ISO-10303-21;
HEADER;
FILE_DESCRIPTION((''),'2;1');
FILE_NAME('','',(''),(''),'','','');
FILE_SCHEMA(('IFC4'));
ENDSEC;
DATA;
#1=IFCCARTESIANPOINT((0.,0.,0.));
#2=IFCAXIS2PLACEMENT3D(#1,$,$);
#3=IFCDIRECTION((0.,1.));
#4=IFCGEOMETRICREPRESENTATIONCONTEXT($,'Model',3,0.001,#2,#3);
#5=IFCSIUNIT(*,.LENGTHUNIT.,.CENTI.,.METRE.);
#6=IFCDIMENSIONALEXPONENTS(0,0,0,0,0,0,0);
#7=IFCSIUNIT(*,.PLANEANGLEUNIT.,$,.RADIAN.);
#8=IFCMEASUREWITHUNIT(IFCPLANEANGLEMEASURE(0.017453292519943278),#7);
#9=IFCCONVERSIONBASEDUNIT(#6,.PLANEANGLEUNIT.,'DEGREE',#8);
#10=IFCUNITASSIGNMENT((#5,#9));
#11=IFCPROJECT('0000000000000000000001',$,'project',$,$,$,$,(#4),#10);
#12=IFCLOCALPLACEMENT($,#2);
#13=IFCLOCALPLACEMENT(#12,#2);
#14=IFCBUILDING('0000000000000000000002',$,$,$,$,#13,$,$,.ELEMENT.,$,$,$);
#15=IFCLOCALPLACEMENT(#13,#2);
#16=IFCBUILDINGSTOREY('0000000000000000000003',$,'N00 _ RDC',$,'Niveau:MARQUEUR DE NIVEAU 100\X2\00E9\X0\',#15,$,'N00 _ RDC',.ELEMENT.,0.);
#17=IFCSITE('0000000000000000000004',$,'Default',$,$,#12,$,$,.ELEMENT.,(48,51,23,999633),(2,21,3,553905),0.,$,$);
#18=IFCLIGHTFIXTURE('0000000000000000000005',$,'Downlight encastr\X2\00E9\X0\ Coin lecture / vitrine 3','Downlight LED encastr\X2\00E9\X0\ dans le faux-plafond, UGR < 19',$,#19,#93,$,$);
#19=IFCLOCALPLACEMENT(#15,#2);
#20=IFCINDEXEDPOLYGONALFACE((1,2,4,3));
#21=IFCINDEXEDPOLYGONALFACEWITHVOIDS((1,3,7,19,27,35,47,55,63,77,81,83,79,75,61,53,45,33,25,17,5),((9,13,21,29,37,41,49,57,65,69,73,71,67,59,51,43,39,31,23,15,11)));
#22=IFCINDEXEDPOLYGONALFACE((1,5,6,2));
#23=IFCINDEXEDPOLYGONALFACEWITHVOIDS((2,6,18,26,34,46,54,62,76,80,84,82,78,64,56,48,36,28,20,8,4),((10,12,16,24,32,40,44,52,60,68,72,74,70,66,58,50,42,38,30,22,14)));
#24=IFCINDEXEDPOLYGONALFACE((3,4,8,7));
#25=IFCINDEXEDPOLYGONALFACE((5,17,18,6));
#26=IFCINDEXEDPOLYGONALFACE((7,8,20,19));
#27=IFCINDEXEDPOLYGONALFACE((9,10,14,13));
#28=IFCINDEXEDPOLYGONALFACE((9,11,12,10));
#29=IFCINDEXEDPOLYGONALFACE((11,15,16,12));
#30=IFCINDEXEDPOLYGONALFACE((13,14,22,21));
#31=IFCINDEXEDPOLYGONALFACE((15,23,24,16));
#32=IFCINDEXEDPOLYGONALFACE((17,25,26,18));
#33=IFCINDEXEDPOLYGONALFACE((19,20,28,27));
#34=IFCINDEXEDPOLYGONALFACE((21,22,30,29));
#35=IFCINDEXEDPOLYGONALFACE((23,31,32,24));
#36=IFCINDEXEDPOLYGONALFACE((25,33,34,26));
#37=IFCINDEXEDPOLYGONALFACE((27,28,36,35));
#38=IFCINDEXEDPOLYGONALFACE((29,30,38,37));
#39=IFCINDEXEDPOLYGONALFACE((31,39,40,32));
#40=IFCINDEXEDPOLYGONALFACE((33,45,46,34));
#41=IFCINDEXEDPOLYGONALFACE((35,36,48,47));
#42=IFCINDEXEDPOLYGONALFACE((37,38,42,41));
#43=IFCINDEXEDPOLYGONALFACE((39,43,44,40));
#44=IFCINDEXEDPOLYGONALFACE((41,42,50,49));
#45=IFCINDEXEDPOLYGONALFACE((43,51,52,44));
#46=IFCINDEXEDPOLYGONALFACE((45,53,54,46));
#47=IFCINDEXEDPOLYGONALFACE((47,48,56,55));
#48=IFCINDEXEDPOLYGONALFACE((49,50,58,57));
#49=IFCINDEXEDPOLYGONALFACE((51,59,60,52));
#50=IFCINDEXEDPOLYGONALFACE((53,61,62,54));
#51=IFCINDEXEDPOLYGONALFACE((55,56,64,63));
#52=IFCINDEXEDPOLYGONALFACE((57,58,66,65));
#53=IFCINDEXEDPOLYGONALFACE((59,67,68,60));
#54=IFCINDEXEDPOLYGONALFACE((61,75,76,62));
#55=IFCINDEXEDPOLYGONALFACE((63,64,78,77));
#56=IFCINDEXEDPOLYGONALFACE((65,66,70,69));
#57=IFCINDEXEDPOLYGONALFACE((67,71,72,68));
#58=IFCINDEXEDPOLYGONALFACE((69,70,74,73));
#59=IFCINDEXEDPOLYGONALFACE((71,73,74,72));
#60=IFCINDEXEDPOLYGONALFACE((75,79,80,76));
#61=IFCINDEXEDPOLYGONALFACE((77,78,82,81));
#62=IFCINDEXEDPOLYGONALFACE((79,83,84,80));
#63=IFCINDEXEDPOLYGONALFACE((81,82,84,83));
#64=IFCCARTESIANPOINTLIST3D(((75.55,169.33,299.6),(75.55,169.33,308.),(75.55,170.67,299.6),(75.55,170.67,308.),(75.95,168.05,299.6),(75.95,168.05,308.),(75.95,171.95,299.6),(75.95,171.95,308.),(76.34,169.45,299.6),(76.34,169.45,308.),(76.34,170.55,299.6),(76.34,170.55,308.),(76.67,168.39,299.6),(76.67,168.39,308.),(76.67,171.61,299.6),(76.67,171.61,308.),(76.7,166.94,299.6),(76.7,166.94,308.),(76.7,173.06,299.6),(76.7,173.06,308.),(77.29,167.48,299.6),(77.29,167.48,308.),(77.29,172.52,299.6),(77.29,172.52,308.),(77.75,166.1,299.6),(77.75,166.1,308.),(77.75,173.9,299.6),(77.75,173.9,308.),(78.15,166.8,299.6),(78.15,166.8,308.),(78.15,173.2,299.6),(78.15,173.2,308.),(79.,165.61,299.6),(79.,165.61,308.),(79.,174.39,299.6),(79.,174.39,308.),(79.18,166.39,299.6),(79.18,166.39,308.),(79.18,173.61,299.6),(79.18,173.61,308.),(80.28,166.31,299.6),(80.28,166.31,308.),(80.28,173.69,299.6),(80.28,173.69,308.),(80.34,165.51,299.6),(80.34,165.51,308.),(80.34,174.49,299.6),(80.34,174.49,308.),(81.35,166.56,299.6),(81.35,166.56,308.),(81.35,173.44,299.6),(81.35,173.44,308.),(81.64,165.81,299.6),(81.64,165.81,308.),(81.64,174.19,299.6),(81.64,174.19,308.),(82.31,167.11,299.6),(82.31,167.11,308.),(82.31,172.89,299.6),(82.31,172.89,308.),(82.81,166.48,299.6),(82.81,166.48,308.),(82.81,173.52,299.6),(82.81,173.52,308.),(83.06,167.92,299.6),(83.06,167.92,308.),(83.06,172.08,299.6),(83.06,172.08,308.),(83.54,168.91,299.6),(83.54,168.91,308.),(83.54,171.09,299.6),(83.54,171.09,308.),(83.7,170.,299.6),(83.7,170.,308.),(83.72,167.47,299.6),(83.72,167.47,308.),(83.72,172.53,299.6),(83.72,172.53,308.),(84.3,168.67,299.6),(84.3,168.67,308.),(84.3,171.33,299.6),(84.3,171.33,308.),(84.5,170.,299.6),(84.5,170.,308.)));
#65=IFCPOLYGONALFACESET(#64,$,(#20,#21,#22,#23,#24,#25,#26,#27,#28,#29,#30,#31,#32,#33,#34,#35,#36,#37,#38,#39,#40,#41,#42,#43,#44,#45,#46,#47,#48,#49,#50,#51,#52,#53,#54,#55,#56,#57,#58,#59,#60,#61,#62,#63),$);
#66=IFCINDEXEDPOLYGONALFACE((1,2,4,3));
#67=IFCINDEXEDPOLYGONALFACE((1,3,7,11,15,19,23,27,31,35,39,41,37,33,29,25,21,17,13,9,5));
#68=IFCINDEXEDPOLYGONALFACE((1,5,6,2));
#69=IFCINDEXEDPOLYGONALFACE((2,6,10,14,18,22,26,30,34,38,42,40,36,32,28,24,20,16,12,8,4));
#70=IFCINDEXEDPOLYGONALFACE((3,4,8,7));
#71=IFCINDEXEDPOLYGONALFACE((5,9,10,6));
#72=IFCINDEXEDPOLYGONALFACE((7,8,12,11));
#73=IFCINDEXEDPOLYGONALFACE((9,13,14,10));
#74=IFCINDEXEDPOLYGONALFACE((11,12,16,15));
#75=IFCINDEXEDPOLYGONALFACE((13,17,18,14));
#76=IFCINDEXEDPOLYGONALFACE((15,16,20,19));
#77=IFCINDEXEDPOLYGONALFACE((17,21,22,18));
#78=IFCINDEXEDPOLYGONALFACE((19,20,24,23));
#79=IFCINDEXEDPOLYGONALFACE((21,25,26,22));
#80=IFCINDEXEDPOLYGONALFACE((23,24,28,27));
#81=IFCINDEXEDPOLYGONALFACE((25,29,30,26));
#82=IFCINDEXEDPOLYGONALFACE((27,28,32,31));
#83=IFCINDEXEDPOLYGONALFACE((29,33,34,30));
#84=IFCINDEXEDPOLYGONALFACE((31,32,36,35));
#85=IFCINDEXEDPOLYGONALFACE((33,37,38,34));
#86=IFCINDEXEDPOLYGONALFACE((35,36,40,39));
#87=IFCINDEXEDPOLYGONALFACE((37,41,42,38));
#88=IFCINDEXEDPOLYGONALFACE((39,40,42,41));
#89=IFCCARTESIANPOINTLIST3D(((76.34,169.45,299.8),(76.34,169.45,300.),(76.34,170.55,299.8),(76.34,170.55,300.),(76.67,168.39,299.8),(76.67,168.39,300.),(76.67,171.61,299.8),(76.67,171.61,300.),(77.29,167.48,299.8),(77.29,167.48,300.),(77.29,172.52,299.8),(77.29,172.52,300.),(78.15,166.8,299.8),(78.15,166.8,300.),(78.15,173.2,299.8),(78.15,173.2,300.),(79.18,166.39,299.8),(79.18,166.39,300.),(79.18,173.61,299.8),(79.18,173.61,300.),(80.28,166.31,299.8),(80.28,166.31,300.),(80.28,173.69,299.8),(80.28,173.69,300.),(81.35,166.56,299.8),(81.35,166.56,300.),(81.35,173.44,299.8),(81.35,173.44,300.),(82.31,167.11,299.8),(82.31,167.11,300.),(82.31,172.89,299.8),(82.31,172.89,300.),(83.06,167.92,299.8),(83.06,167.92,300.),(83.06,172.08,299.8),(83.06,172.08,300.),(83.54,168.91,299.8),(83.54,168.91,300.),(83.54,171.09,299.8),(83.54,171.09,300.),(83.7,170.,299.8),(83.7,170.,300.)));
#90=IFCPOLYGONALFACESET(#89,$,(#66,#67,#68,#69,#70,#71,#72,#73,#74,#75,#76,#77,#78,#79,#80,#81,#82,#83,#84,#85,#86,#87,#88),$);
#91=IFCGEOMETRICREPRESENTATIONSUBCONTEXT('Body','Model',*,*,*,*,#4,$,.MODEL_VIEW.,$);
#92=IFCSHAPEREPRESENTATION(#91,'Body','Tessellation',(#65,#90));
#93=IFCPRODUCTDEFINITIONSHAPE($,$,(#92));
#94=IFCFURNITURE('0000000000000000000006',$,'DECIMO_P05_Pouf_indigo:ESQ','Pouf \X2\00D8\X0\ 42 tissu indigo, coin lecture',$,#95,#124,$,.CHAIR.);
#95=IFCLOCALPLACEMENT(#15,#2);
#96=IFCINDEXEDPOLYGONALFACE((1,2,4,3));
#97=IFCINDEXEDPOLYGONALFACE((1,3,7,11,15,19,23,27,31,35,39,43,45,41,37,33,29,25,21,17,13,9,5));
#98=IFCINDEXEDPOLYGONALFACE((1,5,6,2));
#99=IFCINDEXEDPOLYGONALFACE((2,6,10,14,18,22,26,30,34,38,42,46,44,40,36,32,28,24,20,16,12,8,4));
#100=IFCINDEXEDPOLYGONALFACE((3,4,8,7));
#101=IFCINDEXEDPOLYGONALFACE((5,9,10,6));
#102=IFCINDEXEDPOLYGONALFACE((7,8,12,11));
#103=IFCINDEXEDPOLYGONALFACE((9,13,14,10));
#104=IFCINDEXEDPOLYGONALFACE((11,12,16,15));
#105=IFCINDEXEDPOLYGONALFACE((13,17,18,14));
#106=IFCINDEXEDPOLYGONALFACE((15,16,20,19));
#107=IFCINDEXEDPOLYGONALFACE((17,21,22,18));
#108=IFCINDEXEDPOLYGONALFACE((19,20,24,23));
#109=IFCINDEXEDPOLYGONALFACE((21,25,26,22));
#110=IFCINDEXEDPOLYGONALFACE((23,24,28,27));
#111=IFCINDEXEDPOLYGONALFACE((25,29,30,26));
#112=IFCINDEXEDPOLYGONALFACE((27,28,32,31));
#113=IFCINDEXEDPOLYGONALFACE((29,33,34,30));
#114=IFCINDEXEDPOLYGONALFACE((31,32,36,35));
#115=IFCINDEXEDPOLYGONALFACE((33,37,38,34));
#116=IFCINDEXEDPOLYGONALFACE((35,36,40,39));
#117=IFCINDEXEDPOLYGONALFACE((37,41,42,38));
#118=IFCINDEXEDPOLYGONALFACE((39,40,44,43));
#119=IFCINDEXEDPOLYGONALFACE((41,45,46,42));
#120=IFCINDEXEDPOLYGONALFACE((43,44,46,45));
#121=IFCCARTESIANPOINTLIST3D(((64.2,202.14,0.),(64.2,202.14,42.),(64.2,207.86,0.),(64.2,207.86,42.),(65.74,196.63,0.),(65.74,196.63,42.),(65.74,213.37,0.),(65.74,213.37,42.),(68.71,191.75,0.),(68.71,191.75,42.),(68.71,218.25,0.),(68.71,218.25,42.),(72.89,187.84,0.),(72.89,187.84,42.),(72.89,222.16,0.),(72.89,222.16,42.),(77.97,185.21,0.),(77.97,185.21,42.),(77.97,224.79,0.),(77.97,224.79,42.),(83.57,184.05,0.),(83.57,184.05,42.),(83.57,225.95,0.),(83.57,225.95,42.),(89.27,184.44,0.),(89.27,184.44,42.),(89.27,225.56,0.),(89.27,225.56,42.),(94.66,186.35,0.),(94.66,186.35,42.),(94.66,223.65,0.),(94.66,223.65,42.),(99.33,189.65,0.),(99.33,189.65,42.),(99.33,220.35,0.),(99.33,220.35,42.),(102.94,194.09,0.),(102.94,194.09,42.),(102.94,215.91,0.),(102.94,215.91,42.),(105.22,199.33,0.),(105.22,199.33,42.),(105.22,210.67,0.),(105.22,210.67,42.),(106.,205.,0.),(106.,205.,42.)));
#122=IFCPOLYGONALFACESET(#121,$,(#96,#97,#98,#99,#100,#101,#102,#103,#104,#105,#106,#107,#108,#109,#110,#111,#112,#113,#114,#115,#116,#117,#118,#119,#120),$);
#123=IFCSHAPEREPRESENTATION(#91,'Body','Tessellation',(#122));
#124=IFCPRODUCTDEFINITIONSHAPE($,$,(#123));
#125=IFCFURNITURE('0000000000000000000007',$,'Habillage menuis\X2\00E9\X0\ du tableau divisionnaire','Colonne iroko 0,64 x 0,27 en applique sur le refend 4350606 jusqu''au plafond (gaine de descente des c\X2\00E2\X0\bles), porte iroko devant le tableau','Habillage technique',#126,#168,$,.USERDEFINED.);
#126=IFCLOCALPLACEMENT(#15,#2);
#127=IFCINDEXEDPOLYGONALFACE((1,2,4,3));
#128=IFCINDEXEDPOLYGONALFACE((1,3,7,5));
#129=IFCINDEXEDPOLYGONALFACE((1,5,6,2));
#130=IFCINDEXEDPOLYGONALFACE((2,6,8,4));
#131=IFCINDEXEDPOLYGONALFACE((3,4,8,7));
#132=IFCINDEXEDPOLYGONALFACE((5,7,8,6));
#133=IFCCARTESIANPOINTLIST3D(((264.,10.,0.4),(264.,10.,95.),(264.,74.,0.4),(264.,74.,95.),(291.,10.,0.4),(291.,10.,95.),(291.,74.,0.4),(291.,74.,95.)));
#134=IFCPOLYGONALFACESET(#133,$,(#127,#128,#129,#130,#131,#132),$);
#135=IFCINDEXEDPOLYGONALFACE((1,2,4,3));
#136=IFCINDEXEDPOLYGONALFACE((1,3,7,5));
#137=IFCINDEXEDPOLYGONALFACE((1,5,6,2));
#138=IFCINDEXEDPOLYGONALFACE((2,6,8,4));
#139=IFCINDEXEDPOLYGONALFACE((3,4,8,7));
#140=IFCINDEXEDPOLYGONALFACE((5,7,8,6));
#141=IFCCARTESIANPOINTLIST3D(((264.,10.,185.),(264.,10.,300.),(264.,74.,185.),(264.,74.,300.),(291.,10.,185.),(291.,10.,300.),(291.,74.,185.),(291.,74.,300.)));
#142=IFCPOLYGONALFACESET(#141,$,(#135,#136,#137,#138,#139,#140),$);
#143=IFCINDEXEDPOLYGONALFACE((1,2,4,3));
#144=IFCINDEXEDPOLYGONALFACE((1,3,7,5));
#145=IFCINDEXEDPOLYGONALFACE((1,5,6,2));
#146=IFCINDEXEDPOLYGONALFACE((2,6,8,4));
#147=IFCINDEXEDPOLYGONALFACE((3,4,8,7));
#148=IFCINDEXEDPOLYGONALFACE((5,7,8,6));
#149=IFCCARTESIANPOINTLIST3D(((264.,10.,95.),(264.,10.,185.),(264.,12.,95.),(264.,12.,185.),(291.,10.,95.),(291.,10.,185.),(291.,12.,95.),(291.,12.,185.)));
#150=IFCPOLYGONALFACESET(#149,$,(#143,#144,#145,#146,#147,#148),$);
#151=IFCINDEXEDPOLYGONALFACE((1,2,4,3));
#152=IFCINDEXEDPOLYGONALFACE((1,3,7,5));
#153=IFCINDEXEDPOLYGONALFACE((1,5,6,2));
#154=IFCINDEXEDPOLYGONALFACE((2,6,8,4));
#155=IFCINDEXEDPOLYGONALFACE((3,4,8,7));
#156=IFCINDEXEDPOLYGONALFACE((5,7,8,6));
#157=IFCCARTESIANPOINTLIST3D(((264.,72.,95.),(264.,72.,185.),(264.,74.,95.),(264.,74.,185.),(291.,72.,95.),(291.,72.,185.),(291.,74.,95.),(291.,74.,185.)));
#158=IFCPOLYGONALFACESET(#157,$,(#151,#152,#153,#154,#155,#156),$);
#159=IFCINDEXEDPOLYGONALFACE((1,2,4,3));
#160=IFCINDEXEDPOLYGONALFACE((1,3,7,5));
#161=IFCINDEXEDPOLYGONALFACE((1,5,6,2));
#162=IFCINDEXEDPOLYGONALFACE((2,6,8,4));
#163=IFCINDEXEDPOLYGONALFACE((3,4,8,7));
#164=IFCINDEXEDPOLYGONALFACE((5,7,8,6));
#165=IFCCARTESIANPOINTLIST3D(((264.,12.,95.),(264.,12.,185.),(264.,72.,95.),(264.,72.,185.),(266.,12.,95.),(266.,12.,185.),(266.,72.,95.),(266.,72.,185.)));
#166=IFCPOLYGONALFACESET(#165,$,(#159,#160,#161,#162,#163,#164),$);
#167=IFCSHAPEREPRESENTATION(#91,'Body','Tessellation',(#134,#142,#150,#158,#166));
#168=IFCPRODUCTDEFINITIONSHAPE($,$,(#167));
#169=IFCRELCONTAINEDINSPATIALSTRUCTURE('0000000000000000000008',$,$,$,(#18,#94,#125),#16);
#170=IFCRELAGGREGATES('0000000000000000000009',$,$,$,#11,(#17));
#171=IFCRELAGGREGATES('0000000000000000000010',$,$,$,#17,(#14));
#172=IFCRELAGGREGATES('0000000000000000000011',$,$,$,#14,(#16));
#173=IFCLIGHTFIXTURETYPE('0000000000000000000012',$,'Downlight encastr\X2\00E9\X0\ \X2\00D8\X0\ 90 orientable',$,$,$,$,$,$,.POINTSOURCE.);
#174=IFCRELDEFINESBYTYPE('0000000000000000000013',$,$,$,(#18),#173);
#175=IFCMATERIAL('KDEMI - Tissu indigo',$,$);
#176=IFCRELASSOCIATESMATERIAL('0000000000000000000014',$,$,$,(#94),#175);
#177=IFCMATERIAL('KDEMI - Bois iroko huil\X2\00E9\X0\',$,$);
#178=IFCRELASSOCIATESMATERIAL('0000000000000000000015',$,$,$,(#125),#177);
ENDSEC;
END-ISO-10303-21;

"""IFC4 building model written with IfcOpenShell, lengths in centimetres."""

from ifc_helpers import new_model, entity, si_unit, converted_unit, direction, frame, frame_2d, origin, origin_with_axes, place, context, subcontext, project, spatial, rectangle, circle, hollow_circle, extrude, material, type_object, element, save


model = new_model("IFC4")

# Units and contexts
model_context = context("Model", 3, precision=0.001, world=origin(), true_north=direction((0.0, 1.0)))
body_context = subcontext(model_context, "Body", "Model", "MODEL_VIEW")
ifc_project = project(units=[si_unit("LENGTHUNIT", "METRE", prefix="CENTI"), converted_unit("PLANEANGLEUNIT", "DEGREE", entity("IfcPlaneAngleMeasure", 0.017453292519943278), si_unit("PLANEANGLEUNIT", "RADIAN"), dimensions=[0, 0, 0, 0, 0, 0, 0])], contexts=[model_context])

# Site, building, storey
site_placement = place(None, origin())
site = spatial("IfcSite", under=ifc_project, at=site_placement, Name="Default", CompositionType="ELEMENT", RefLatitude=(48, 51, 23, 999633), RefLongitude=(2, 21, 3, 553905), RefElevation=0.0)
building_placement = place(site_placement, origin())
building = spatial("IfcBuilding", under=site, at=building_placement, CompositionType="ELEMENT")
storey_placement = place(building_placement, origin())
storey = spatial("IfcBuildingStorey", under=building, at=storey_placement, Name="N00 _ RDC", ObjectType="Niveau:MARQUEUR DE NIVEAU 100é", LongName="N00 _ RDC", CompositionType="ELEMENT", Elevation=0.0)

# Light fixture
light_fixture_type_1 = type_object("IfcLightFixtureType", Name="Downlight encastré Ø 90 orientable", PredefinedType="POINTSOURCE")
light_fixture_1_placement = place(storey_placement, origin_with_axes())
element("IfcLightFixture", 1, at=light_fixture_1_placement, inside=storey, type_object=light_fixture_type_1, Name="Downlight encastré Coin lecture / vitrine 3", Description="Downlight LED encastré dans le faux-plafond, UGR < 19", context=body_context, shape_type="SweptSolid", body=[
    extrude(hollow_circle(Radius=4.5, WallThickness=0.8, at=frame_2d((80.0, 170.0))), frame((0.0, 0.0, 299.6)), (0.0, 0.0, 1.0), 8.4),
    extrude(circle(Radius=3.7, at=frame_2d((80.0, 170.0))), frame((0.0, 0.0, 299.8)), (0.0, 0.0, 1.0), 0.2),
])

# Furniture
ifc_material_1 = material(Name="KDEMI - Tissu indigo")
furniture_1_placement = place(storey_placement, origin_with_axes())
element("IfcFurniture", 2, at=furniture_1_placement, inside=storey, material=ifc_material_1, Name="DECIMO_P05_Pouf_indigo:ESQ", Description="Pouf Ø 42 tissu indigo, coin lecture", PredefinedType="CHAIR", context=body_context, shape_type="SweptSolid", body=[
    extrude(circle(Radius=21.0, at=frame_2d((85.0, 205.0))), origin(), (0.0, 0.0, 1.0), 42.0),
])
ifc_material_2 = material(Name="KDEMI - Bois iroko huilé")
furniture_2_placement = place(storey_placement, origin_with_axes())
element("IfcFurniture", 3, at=furniture_2_placement, inside=storey, material=ifc_material_2, Name="Habillage menuisé du tableau divisionnaire", Description="Colonne iroko 0,64 x 0,27 en applique sur le refend 4350606 jusqu'au plafond (gaine de descente des câbles), porte iroko devant le tableau", ObjectType="Habillage technique", PredefinedType="USERDEFINED", context=body_context, shape_type="SweptSolid", body=[
    extrude(rectangle(XDim=27.0, YDim=64.0, at=frame_2d((277.5, 42.0))), frame((0.0, 0.0, 0.4)), (0.0, 0.0, 1.0), 94.6),
    extrude(rectangle(XDim=27.0, YDim=64.0, at=frame_2d((277.5, 42.0))), frame((0.0, 0.0, 185.0)), (0.0, 0.0, 1.0), 115.0),
    extrude(rectangle(XDim=27.0, YDim=2.0, at=frame_2d((277.5, 11.0))), frame((0.0, 0.0, 95.0)), (0.0, 0.0, 1.0), 90.0),
    extrude(rectangle(XDim=27.0, YDim=2.0, at=frame_2d((277.5, 73.0))), frame((0.0, 0.0, 95.0)), (0.0, 0.0, 1.0), 90.0),
    extrude(rectangle(XDim=2.0, YDim=60.0, at=frame_2d((265.0, 42.0))), frame((0.0, 0.0, 95.0)), (0.0, 0.0, 1.0), 90.0),
])

save(model, "model.ifc")
